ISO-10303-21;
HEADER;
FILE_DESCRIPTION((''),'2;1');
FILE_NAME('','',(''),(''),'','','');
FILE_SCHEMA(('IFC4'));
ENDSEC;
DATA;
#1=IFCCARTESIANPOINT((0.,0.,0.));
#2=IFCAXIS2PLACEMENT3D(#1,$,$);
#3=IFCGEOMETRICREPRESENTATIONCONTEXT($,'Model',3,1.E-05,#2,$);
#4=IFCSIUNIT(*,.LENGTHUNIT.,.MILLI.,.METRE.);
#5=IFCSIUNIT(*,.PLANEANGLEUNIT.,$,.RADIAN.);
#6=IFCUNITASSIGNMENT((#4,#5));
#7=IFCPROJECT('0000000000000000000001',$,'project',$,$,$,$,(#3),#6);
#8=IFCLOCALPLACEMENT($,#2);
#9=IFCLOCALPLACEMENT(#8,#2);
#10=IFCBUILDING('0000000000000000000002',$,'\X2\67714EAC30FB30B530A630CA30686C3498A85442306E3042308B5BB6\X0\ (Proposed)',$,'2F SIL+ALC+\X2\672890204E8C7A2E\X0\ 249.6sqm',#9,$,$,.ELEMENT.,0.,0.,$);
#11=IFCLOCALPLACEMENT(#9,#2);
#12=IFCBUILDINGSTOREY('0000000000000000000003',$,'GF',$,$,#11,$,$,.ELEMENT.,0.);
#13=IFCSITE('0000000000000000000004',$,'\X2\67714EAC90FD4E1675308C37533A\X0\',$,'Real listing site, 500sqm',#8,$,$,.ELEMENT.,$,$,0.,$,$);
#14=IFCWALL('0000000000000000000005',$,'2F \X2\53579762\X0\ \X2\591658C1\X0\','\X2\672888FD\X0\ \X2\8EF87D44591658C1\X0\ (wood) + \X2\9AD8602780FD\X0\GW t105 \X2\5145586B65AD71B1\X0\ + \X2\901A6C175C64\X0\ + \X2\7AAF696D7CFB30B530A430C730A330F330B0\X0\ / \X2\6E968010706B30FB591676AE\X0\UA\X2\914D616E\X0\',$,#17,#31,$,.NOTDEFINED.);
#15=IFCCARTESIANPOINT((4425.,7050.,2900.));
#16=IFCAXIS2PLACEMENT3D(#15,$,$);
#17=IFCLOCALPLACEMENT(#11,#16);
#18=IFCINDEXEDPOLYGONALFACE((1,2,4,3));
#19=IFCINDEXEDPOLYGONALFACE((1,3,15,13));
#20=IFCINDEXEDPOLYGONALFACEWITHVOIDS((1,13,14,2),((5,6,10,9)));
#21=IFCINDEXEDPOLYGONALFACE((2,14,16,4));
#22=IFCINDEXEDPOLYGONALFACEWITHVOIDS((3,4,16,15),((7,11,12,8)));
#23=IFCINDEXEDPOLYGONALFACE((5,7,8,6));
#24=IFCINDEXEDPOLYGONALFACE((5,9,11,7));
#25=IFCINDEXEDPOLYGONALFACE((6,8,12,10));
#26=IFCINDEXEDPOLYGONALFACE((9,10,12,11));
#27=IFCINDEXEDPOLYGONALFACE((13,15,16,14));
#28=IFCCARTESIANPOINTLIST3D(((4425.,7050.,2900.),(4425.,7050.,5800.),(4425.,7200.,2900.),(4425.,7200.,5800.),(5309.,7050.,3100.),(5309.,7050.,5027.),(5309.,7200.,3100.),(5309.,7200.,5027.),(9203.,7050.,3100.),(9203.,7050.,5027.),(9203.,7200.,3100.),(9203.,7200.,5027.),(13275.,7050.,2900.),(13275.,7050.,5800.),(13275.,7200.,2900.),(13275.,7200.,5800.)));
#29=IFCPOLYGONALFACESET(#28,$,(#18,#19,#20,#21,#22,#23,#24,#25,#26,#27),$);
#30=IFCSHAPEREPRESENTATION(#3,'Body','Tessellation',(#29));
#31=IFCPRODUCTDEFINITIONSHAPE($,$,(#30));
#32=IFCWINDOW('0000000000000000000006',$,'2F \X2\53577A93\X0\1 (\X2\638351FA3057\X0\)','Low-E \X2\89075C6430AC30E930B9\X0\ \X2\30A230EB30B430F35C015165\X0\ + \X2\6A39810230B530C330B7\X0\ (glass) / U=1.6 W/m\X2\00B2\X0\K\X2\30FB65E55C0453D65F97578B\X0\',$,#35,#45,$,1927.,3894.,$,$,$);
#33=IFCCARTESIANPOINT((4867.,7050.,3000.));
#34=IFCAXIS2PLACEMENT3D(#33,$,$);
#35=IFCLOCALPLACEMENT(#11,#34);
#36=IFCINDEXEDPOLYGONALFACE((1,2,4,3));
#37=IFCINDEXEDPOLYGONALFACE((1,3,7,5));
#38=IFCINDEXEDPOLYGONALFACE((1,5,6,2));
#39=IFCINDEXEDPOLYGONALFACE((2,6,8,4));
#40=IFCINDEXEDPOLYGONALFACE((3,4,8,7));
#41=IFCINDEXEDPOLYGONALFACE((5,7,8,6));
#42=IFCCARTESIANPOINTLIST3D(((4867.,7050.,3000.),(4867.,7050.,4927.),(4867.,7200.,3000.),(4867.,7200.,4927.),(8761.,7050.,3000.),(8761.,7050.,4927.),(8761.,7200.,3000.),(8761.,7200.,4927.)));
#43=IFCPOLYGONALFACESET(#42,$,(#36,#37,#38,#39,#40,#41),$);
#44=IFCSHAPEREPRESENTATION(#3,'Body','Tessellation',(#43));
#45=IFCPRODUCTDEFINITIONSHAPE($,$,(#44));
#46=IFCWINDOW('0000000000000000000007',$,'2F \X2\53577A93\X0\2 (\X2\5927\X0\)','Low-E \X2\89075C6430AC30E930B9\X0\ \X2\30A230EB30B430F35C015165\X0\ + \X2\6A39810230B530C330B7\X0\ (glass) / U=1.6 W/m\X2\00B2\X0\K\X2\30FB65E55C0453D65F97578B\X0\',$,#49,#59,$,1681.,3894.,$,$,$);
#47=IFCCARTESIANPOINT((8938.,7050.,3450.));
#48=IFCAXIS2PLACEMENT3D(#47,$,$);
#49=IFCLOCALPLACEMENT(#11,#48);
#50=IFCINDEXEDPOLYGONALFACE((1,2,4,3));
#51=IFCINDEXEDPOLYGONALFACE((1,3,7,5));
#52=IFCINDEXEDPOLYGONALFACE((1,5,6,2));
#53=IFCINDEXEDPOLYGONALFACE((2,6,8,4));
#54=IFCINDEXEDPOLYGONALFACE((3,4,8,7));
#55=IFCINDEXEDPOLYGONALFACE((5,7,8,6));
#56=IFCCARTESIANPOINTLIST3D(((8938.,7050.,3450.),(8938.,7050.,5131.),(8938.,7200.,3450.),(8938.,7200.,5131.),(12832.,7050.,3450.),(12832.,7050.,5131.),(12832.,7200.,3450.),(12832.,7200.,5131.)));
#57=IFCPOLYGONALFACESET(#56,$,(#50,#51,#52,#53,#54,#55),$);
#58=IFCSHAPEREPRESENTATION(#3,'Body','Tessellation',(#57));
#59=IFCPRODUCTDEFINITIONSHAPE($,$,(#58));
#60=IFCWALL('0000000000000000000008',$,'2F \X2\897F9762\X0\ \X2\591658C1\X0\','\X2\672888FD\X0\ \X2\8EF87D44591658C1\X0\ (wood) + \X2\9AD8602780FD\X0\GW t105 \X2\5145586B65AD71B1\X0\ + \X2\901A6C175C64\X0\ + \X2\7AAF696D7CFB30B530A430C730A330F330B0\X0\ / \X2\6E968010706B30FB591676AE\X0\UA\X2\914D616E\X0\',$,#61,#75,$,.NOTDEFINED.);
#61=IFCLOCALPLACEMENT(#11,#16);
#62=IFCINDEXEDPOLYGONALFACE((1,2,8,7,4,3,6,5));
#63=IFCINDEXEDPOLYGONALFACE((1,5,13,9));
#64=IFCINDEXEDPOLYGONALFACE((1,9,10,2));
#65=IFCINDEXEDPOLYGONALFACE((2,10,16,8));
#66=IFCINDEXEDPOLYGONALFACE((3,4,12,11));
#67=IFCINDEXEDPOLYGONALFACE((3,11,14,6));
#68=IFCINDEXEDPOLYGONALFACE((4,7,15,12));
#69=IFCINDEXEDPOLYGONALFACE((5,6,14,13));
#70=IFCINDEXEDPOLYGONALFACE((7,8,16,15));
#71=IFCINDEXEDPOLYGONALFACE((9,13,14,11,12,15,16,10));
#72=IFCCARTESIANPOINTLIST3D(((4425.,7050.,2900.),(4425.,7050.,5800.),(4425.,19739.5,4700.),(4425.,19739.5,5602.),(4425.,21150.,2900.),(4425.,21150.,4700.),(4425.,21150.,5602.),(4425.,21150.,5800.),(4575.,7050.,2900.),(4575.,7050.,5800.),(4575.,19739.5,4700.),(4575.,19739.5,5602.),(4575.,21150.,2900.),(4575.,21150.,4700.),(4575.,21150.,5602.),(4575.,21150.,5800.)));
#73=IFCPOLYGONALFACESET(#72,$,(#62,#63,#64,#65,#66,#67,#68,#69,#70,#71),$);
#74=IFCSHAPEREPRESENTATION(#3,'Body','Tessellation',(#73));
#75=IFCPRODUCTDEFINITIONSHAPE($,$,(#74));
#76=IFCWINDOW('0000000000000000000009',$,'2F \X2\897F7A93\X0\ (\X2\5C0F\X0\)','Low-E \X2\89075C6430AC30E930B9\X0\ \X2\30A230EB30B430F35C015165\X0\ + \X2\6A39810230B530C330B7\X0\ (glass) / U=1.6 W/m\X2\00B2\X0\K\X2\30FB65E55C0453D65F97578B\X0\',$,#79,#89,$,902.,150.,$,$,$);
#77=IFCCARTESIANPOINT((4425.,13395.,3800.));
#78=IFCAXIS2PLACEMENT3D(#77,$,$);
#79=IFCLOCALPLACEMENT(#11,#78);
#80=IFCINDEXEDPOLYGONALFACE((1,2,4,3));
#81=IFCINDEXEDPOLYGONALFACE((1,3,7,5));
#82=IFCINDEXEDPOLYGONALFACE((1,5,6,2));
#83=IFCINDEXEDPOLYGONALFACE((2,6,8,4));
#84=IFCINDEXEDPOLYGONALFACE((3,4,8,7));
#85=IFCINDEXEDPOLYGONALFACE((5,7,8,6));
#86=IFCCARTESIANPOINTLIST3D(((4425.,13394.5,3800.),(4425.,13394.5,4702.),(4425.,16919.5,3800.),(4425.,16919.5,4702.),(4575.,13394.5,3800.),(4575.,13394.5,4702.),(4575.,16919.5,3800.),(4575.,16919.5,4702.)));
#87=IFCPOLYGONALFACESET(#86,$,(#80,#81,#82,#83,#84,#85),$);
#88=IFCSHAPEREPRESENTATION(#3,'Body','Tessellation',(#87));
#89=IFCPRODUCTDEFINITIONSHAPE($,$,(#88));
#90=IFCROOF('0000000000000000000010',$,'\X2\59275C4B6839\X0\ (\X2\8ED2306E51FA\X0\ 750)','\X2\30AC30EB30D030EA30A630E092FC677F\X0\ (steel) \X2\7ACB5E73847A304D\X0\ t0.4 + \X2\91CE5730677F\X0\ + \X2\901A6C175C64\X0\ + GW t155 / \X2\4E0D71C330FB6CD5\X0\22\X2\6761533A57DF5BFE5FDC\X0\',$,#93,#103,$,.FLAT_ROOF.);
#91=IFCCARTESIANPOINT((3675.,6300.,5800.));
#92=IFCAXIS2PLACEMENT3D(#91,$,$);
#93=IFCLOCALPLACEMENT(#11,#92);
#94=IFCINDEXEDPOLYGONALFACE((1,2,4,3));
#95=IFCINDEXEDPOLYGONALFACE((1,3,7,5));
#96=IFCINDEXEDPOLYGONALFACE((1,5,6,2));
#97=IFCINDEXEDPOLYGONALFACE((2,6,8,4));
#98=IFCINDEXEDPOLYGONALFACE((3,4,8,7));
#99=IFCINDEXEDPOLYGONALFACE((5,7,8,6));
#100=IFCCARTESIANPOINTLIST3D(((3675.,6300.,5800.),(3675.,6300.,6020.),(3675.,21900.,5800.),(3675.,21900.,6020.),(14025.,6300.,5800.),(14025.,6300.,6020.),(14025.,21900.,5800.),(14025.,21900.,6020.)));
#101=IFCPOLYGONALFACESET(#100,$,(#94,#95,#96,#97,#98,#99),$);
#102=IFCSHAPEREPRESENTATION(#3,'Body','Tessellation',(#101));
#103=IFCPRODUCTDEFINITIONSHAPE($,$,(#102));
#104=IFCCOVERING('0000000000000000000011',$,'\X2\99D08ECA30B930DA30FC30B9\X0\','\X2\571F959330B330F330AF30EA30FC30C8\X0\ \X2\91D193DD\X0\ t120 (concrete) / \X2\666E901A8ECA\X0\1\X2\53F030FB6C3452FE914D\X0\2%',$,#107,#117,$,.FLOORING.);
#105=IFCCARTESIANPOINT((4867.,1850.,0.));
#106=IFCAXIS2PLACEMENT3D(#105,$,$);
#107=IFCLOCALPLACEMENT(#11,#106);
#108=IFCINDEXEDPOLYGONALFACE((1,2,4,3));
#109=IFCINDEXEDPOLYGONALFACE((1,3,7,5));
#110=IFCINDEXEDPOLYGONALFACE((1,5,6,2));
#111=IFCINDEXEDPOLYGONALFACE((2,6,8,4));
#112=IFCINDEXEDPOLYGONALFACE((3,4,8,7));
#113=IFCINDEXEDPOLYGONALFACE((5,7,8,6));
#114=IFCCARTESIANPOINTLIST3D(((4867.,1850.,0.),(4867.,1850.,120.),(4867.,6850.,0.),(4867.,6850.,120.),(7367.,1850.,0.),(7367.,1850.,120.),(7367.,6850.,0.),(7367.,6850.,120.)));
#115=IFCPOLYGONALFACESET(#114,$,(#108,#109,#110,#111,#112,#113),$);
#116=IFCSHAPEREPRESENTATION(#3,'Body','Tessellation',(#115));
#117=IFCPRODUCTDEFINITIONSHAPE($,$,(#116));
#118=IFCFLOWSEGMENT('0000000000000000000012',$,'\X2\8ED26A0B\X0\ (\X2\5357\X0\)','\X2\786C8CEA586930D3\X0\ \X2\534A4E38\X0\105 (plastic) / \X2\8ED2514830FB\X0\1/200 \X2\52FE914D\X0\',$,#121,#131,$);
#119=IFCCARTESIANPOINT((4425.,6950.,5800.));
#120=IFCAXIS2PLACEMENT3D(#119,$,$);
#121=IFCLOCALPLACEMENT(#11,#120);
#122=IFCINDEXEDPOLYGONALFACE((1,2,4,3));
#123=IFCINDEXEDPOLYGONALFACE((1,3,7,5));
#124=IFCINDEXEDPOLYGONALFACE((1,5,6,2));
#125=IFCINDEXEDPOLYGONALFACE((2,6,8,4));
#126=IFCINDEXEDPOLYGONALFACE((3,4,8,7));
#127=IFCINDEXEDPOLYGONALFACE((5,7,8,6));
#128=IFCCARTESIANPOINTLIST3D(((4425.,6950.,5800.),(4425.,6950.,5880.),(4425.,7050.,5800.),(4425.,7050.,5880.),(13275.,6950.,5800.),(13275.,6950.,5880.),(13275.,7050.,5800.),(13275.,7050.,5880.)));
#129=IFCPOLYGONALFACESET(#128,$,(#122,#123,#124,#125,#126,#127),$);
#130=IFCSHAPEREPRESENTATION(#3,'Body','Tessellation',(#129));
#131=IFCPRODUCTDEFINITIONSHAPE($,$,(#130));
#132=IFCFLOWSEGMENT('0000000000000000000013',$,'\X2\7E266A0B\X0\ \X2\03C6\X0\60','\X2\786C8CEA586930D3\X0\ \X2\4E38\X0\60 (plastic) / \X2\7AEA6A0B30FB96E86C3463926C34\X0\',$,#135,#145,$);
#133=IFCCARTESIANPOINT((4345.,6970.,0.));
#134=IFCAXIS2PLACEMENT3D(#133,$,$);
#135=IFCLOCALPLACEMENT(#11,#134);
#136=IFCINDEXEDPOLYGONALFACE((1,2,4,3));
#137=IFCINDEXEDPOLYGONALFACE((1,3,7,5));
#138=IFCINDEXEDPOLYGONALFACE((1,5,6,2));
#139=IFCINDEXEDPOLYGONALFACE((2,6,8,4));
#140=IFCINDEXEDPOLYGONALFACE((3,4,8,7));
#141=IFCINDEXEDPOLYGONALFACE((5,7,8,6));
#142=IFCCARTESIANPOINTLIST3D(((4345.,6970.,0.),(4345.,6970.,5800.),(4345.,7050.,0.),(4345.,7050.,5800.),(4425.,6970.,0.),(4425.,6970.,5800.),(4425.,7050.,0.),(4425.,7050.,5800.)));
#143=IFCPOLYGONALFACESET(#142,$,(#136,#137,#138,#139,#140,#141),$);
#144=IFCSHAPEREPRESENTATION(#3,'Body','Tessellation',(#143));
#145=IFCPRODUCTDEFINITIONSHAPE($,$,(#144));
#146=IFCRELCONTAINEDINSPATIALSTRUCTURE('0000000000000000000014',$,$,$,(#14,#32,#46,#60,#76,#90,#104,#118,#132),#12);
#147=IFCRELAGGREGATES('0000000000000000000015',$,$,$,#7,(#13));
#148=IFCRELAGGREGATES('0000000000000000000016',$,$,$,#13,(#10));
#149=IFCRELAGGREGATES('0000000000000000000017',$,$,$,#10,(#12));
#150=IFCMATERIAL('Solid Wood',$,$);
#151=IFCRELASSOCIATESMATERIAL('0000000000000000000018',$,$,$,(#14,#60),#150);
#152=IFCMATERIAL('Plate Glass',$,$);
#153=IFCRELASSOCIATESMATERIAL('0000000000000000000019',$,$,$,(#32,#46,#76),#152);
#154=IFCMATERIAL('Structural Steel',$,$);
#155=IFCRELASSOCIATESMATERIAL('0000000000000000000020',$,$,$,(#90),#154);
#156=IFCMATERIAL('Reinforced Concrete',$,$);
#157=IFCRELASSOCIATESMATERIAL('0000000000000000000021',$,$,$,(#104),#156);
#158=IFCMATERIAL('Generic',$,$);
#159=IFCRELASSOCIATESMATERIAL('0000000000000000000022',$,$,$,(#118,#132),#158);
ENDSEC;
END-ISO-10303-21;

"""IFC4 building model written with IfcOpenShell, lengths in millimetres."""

from ifc_helpers import new_model, si_unit, frame, frame_2d, origin, place, context, project, spatial, rectangle, extrude, material, element, fill, save


model = new_model("IFC4")

# Units and contexts
model_context = context("Model", 3, precision=1e-05, world=origin())
ifc_project = project(units=[si_unit("LENGTHUNIT", "METRE", prefix="MILLI"), si_unit("PLANEANGLEUNIT", "RADIAN")], contexts=[model_context])

# Site, building, storey
site_placement = place(None, origin())
site = spatial("IfcSite", under=ifc_project, at=site_placement, Name="東京都世田谷区", ObjectType="Real listing site, 500sqm", CompositionType="ELEMENT", RefElevation=0.0)
building_placement = place(site_placement, origin())
building = spatial("IfcBuilding", under=site, at=building_placement, Name="東京・サウナと水風呂のある家 (Proposed)", ObjectType="2F SIL+ALC+木造二種 249.6sqm", CompositionType="ELEMENT", ElevationOfRefHeight=0.0, ElevationOfTerrain=0.0)
storey_placement = place(building_placement, origin())
storey = spatial("IfcBuildingStorey", under=building, at=storey_placement, Name="GF", CompositionType="ELEMENT", Elevation=0.0)

# Shared definitions
ifc_material_1 = material(Name="Solid Wood")

# Shared definitions
ifc_material_2 = material(Name="Reinforced Concrete")

# Shared definitions
ifc_material_3 = material(Name="Plate Glass")

# Wall, openings, windows
wall_1_placement = place(storey_placement, frame((4425.0, 7050.0, 2900.0)))
wall_1 = element("IfcWall", 1, at=wall_1_placement, inside=storey, material=ifc_material_1, Name="2F 南面 外壁", Description="木製 軸組外壁 (wood) + 高性能GW t105 充填断熱 + 通気層 + 窯業系サイディング / 準耐火・外皮UA配慮", PredefinedType="NOTDEFINED", context=model_context, shape_type="SweptSolid", body=[
    extrude(rectangle(XDim=8850.0, YDim=150.0, at=frame_2d((4425.0, 75.0))), frame((4425.0, 7050.0, 2900.0)), (0.0, 0.0, 1.0), 2900.0),
])
opening_1_placement = place(storey_placement, frame((4867.0, 7050.0, 3000.0)))
opening_1 = element("IfcOpeningElement", 2, at=opening_1_placement, cuts=wall_1, PredefinedType="NOTDEFINED", context=model_context, shape_type="SweptSolid", body=[
    extrude(rectangle(XDim=3894.0, YDim=150.0, at=frame_2d((1947.0, 75.0))), frame((4867.0, 7050.0, 3000.0)), (0.0, 0.0, 1.0), 1927.0),
])
opening_2_placement = place(storey_placement, frame((8938.0, 7050.0, 3450.0)))
opening_2 = element("IfcOpeningElement", 3, at=opening_2_placement, cuts=wall_1, PredefinedType="NOTDEFINED", context=model_context, shape_type="SweptSolid", body=[
    extrude(rectangle(XDim=3894.0, YDim=150.0, at=frame_2d((1947.0, 75.0))), frame((8938.0, 7050.0, 3450.0)), (0.0, 0.0, 1.0), 1681.0),
])
window_1_placement = place(storey_placement, frame((4867.0, 7050.0, 3000.0)))
window_1 = element("IfcWindow", 4, at=window_1_placement, inside=storey, material=ifc_material_3, Name="2F 南窓1 (掃出し)", Description="Low-E 複層ガラス アルゴン封入 + 樹脂サッシ (glass) / U=1.6 W/m²K・日射取得型", OverallHeight=1927.0, OverallWidth=3894.0, context=model_context, shape_type="SweptSolid", body=[
    extrude(rectangle(XDim=3894.0, YDim=150.0, at=frame_2d((1947.0, 75.0))), frame((4867.0, 7050.0, 3000.0)), (0.0, 0.0, 1.0), 1927.0),
])
fill(opening_1, window_1)
window_2_placement = place(storey_placement, frame((8938.0, 7050.0, 3450.0)))
window_2 = element("IfcWindow", 5, at=window_2_placement, inside=storey, material=ifc_material_3, Name="2F 南窓2 (大)", Description="Low-E 複層ガラス アルゴン封入 + 樹脂サッシ (glass) / U=1.6 W/m²K・日射取得型", OverallHeight=1681.0, OverallWidth=3894.0, context=model_context, shape_type="SweptSolid", body=[
    extrude(rectangle(XDim=3894.0, YDim=150.0, at=frame_2d((1947.0, 75.0))), frame((8938.0, 7050.0, 3450.0)), (0.0, 0.0, 1.0), 1681.0),
])
fill(opening_2, window_2)

# Wall, opening, window
wall_2_placement = place(storey_placement, frame((4425.0, 7050.0, 2900.0)))
wall_2 = element("IfcWall", 6, at=wall_2_placement, inside=storey, material=ifc_material_1, Name="2F 西面 外壁", Description="木製 軸組外壁 (wood) + 高性能GW t105 充填断熱 + 通気層 + 窯業系サイディング / 準耐火・外皮UA配慮", PredefinedType="NOTDEFINED", context=model_context, shape_type="SweptSolid", body=[
    extrude(rectangle(XDim=150.0, YDim=14100.0, at=frame_2d((75.0, 7050.0))), frame((4425.0, 7050.0, 2900.0)), (0.0, 0.0, 1.0), 2900.0),
])
opening_3_placement = place(storey_placement, frame((4425.0, 13395.0, 3800.0)))
opening_3 = element("IfcOpeningElement", 7, at=opening_3_placement, cuts=wall_2, PredefinedType="NOTDEFINED", context=model_context, shape_type="SweptSolid", body=[
    extrude(rectangle(XDim=150.0, YDim=3525.0, at=frame_2d((75.0, 1762.0))), frame((4425.0, 13395.0, 3800.0)), (0.0, 0.0, 1.0), 902.0),
])
window_3_placement = place(storey_placement, frame((4425.0, 13395.0, 3800.0)))
window_3 = element("IfcWindow", 8, at=window_3_placement, inside=storey, material=ifc_material_3, Name="2F 西窓 (小)", Description="Low-E 複層ガラス アルゴン封入 + 樹脂サッシ (glass) / U=1.6 W/m²K・日射取得型", OverallHeight=902.0, OverallWidth=150.0, context=model_context, shape_type="SweptSolid", body=[
    extrude(rectangle(XDim=150.0, YDim=3525.0, at=frame_2d((75.0, 1762.0))), frame((4425.0, 13395.0, 3800.0)), (0.0, 0.0, 1.0), 902.0),
])
fill(opening_3, window_3)

# Roof
ifc_material_4 = material(Name="Structural Steel")
roof_placement = place(storey_placement, frame((3675.0, 6300.0, 5800.0)))
element("IfcRoof", 9, at=roof_placement, inside=storey, material=ifc_material_4, Name="大屋根 (軒の出 750)", Description="ガルバリウム鋼板 (steel) 立平葺き t0.4 + 野地板 + 通気層 + GW t155 / 不燃・法22条区域対応", PredefinedType="FLAT_ROOF", context=model_context, shape_type="SweptSolid", body=[
    extrude(rectangle(XDim=10350.0, YDim=15600.0, at=frame_2d((5175.0, 7800.0))), frame((3675.0, 6300.0, 5800.0)), (0.0, 0.0, 1.0), 220.0),
])

# Covering
covering_placement = place(storey_placement, frame((4867.0, 1850.0, 0.0)))
element("IfcCovering", 10, at=covering_placement, inside=storey, material=ifc_material_2, Name="駐車スペース", Description="土間コンクリート 金鏝 t120 (concrete) / 普通車1台・水勾配2%", PredefinedType="FLOORING", context=model_context, shape_type="SweptSolid", body=[
    extrude(rectangle(XDim=2500.0, YDim=5000.0, at=frame_2d((1250.0, 2500.0))), frame((4867.0, 1850.0, 0.0)), (0.0, 0.0, 1.0), 120.0),
])

# Flow segments
ifc_material_5 = material(Name="Generic")
flow_segment_1_placement = place(storey_placement, frame((4425.0, 6950.0, 5800.0)))
element("IfcFlowSegment", 11, at=flow_segment_1_placement, inside=storey, material=ifc_material_5, Name="軒樋 (南)", Description="硬質塩ビ 半丸105 (plastic) / 軒先・1/200 勾配", context=model_context, shape_type="SweptSolid", body=[
    extrude(rectangle(XDim=8850.0, YDim=100.0, at=frame_2d((4425.0, 50.0))), frame((4425.0, 6950.0, 5800.0)), (0.0, 0.0, 1.0), 80.0),
])
flow_segment_2_placement = place(storey_placement, frame((4345.0, 6970.0, 0.0)))
element("IfcFlowSegment", 12, at=flow_segment_2_placement, inside=storey, material=ifc_material_5, Name="縦樋 φ60", Description="硬質塩ビ 丸60 (plastic) / 竪樋・雨水排水", context=model_context, shape_type="SweptSolid", body=[
    extrude(rectangle(XDim=80.0, YDim=80.0, at=frame_2d((40.0, 40.0))), frame((4345.0, 6970.0, 0.0)), (0.0, 0.0, 1.0), 5800.0),
])

save(model, "model.ifc")
